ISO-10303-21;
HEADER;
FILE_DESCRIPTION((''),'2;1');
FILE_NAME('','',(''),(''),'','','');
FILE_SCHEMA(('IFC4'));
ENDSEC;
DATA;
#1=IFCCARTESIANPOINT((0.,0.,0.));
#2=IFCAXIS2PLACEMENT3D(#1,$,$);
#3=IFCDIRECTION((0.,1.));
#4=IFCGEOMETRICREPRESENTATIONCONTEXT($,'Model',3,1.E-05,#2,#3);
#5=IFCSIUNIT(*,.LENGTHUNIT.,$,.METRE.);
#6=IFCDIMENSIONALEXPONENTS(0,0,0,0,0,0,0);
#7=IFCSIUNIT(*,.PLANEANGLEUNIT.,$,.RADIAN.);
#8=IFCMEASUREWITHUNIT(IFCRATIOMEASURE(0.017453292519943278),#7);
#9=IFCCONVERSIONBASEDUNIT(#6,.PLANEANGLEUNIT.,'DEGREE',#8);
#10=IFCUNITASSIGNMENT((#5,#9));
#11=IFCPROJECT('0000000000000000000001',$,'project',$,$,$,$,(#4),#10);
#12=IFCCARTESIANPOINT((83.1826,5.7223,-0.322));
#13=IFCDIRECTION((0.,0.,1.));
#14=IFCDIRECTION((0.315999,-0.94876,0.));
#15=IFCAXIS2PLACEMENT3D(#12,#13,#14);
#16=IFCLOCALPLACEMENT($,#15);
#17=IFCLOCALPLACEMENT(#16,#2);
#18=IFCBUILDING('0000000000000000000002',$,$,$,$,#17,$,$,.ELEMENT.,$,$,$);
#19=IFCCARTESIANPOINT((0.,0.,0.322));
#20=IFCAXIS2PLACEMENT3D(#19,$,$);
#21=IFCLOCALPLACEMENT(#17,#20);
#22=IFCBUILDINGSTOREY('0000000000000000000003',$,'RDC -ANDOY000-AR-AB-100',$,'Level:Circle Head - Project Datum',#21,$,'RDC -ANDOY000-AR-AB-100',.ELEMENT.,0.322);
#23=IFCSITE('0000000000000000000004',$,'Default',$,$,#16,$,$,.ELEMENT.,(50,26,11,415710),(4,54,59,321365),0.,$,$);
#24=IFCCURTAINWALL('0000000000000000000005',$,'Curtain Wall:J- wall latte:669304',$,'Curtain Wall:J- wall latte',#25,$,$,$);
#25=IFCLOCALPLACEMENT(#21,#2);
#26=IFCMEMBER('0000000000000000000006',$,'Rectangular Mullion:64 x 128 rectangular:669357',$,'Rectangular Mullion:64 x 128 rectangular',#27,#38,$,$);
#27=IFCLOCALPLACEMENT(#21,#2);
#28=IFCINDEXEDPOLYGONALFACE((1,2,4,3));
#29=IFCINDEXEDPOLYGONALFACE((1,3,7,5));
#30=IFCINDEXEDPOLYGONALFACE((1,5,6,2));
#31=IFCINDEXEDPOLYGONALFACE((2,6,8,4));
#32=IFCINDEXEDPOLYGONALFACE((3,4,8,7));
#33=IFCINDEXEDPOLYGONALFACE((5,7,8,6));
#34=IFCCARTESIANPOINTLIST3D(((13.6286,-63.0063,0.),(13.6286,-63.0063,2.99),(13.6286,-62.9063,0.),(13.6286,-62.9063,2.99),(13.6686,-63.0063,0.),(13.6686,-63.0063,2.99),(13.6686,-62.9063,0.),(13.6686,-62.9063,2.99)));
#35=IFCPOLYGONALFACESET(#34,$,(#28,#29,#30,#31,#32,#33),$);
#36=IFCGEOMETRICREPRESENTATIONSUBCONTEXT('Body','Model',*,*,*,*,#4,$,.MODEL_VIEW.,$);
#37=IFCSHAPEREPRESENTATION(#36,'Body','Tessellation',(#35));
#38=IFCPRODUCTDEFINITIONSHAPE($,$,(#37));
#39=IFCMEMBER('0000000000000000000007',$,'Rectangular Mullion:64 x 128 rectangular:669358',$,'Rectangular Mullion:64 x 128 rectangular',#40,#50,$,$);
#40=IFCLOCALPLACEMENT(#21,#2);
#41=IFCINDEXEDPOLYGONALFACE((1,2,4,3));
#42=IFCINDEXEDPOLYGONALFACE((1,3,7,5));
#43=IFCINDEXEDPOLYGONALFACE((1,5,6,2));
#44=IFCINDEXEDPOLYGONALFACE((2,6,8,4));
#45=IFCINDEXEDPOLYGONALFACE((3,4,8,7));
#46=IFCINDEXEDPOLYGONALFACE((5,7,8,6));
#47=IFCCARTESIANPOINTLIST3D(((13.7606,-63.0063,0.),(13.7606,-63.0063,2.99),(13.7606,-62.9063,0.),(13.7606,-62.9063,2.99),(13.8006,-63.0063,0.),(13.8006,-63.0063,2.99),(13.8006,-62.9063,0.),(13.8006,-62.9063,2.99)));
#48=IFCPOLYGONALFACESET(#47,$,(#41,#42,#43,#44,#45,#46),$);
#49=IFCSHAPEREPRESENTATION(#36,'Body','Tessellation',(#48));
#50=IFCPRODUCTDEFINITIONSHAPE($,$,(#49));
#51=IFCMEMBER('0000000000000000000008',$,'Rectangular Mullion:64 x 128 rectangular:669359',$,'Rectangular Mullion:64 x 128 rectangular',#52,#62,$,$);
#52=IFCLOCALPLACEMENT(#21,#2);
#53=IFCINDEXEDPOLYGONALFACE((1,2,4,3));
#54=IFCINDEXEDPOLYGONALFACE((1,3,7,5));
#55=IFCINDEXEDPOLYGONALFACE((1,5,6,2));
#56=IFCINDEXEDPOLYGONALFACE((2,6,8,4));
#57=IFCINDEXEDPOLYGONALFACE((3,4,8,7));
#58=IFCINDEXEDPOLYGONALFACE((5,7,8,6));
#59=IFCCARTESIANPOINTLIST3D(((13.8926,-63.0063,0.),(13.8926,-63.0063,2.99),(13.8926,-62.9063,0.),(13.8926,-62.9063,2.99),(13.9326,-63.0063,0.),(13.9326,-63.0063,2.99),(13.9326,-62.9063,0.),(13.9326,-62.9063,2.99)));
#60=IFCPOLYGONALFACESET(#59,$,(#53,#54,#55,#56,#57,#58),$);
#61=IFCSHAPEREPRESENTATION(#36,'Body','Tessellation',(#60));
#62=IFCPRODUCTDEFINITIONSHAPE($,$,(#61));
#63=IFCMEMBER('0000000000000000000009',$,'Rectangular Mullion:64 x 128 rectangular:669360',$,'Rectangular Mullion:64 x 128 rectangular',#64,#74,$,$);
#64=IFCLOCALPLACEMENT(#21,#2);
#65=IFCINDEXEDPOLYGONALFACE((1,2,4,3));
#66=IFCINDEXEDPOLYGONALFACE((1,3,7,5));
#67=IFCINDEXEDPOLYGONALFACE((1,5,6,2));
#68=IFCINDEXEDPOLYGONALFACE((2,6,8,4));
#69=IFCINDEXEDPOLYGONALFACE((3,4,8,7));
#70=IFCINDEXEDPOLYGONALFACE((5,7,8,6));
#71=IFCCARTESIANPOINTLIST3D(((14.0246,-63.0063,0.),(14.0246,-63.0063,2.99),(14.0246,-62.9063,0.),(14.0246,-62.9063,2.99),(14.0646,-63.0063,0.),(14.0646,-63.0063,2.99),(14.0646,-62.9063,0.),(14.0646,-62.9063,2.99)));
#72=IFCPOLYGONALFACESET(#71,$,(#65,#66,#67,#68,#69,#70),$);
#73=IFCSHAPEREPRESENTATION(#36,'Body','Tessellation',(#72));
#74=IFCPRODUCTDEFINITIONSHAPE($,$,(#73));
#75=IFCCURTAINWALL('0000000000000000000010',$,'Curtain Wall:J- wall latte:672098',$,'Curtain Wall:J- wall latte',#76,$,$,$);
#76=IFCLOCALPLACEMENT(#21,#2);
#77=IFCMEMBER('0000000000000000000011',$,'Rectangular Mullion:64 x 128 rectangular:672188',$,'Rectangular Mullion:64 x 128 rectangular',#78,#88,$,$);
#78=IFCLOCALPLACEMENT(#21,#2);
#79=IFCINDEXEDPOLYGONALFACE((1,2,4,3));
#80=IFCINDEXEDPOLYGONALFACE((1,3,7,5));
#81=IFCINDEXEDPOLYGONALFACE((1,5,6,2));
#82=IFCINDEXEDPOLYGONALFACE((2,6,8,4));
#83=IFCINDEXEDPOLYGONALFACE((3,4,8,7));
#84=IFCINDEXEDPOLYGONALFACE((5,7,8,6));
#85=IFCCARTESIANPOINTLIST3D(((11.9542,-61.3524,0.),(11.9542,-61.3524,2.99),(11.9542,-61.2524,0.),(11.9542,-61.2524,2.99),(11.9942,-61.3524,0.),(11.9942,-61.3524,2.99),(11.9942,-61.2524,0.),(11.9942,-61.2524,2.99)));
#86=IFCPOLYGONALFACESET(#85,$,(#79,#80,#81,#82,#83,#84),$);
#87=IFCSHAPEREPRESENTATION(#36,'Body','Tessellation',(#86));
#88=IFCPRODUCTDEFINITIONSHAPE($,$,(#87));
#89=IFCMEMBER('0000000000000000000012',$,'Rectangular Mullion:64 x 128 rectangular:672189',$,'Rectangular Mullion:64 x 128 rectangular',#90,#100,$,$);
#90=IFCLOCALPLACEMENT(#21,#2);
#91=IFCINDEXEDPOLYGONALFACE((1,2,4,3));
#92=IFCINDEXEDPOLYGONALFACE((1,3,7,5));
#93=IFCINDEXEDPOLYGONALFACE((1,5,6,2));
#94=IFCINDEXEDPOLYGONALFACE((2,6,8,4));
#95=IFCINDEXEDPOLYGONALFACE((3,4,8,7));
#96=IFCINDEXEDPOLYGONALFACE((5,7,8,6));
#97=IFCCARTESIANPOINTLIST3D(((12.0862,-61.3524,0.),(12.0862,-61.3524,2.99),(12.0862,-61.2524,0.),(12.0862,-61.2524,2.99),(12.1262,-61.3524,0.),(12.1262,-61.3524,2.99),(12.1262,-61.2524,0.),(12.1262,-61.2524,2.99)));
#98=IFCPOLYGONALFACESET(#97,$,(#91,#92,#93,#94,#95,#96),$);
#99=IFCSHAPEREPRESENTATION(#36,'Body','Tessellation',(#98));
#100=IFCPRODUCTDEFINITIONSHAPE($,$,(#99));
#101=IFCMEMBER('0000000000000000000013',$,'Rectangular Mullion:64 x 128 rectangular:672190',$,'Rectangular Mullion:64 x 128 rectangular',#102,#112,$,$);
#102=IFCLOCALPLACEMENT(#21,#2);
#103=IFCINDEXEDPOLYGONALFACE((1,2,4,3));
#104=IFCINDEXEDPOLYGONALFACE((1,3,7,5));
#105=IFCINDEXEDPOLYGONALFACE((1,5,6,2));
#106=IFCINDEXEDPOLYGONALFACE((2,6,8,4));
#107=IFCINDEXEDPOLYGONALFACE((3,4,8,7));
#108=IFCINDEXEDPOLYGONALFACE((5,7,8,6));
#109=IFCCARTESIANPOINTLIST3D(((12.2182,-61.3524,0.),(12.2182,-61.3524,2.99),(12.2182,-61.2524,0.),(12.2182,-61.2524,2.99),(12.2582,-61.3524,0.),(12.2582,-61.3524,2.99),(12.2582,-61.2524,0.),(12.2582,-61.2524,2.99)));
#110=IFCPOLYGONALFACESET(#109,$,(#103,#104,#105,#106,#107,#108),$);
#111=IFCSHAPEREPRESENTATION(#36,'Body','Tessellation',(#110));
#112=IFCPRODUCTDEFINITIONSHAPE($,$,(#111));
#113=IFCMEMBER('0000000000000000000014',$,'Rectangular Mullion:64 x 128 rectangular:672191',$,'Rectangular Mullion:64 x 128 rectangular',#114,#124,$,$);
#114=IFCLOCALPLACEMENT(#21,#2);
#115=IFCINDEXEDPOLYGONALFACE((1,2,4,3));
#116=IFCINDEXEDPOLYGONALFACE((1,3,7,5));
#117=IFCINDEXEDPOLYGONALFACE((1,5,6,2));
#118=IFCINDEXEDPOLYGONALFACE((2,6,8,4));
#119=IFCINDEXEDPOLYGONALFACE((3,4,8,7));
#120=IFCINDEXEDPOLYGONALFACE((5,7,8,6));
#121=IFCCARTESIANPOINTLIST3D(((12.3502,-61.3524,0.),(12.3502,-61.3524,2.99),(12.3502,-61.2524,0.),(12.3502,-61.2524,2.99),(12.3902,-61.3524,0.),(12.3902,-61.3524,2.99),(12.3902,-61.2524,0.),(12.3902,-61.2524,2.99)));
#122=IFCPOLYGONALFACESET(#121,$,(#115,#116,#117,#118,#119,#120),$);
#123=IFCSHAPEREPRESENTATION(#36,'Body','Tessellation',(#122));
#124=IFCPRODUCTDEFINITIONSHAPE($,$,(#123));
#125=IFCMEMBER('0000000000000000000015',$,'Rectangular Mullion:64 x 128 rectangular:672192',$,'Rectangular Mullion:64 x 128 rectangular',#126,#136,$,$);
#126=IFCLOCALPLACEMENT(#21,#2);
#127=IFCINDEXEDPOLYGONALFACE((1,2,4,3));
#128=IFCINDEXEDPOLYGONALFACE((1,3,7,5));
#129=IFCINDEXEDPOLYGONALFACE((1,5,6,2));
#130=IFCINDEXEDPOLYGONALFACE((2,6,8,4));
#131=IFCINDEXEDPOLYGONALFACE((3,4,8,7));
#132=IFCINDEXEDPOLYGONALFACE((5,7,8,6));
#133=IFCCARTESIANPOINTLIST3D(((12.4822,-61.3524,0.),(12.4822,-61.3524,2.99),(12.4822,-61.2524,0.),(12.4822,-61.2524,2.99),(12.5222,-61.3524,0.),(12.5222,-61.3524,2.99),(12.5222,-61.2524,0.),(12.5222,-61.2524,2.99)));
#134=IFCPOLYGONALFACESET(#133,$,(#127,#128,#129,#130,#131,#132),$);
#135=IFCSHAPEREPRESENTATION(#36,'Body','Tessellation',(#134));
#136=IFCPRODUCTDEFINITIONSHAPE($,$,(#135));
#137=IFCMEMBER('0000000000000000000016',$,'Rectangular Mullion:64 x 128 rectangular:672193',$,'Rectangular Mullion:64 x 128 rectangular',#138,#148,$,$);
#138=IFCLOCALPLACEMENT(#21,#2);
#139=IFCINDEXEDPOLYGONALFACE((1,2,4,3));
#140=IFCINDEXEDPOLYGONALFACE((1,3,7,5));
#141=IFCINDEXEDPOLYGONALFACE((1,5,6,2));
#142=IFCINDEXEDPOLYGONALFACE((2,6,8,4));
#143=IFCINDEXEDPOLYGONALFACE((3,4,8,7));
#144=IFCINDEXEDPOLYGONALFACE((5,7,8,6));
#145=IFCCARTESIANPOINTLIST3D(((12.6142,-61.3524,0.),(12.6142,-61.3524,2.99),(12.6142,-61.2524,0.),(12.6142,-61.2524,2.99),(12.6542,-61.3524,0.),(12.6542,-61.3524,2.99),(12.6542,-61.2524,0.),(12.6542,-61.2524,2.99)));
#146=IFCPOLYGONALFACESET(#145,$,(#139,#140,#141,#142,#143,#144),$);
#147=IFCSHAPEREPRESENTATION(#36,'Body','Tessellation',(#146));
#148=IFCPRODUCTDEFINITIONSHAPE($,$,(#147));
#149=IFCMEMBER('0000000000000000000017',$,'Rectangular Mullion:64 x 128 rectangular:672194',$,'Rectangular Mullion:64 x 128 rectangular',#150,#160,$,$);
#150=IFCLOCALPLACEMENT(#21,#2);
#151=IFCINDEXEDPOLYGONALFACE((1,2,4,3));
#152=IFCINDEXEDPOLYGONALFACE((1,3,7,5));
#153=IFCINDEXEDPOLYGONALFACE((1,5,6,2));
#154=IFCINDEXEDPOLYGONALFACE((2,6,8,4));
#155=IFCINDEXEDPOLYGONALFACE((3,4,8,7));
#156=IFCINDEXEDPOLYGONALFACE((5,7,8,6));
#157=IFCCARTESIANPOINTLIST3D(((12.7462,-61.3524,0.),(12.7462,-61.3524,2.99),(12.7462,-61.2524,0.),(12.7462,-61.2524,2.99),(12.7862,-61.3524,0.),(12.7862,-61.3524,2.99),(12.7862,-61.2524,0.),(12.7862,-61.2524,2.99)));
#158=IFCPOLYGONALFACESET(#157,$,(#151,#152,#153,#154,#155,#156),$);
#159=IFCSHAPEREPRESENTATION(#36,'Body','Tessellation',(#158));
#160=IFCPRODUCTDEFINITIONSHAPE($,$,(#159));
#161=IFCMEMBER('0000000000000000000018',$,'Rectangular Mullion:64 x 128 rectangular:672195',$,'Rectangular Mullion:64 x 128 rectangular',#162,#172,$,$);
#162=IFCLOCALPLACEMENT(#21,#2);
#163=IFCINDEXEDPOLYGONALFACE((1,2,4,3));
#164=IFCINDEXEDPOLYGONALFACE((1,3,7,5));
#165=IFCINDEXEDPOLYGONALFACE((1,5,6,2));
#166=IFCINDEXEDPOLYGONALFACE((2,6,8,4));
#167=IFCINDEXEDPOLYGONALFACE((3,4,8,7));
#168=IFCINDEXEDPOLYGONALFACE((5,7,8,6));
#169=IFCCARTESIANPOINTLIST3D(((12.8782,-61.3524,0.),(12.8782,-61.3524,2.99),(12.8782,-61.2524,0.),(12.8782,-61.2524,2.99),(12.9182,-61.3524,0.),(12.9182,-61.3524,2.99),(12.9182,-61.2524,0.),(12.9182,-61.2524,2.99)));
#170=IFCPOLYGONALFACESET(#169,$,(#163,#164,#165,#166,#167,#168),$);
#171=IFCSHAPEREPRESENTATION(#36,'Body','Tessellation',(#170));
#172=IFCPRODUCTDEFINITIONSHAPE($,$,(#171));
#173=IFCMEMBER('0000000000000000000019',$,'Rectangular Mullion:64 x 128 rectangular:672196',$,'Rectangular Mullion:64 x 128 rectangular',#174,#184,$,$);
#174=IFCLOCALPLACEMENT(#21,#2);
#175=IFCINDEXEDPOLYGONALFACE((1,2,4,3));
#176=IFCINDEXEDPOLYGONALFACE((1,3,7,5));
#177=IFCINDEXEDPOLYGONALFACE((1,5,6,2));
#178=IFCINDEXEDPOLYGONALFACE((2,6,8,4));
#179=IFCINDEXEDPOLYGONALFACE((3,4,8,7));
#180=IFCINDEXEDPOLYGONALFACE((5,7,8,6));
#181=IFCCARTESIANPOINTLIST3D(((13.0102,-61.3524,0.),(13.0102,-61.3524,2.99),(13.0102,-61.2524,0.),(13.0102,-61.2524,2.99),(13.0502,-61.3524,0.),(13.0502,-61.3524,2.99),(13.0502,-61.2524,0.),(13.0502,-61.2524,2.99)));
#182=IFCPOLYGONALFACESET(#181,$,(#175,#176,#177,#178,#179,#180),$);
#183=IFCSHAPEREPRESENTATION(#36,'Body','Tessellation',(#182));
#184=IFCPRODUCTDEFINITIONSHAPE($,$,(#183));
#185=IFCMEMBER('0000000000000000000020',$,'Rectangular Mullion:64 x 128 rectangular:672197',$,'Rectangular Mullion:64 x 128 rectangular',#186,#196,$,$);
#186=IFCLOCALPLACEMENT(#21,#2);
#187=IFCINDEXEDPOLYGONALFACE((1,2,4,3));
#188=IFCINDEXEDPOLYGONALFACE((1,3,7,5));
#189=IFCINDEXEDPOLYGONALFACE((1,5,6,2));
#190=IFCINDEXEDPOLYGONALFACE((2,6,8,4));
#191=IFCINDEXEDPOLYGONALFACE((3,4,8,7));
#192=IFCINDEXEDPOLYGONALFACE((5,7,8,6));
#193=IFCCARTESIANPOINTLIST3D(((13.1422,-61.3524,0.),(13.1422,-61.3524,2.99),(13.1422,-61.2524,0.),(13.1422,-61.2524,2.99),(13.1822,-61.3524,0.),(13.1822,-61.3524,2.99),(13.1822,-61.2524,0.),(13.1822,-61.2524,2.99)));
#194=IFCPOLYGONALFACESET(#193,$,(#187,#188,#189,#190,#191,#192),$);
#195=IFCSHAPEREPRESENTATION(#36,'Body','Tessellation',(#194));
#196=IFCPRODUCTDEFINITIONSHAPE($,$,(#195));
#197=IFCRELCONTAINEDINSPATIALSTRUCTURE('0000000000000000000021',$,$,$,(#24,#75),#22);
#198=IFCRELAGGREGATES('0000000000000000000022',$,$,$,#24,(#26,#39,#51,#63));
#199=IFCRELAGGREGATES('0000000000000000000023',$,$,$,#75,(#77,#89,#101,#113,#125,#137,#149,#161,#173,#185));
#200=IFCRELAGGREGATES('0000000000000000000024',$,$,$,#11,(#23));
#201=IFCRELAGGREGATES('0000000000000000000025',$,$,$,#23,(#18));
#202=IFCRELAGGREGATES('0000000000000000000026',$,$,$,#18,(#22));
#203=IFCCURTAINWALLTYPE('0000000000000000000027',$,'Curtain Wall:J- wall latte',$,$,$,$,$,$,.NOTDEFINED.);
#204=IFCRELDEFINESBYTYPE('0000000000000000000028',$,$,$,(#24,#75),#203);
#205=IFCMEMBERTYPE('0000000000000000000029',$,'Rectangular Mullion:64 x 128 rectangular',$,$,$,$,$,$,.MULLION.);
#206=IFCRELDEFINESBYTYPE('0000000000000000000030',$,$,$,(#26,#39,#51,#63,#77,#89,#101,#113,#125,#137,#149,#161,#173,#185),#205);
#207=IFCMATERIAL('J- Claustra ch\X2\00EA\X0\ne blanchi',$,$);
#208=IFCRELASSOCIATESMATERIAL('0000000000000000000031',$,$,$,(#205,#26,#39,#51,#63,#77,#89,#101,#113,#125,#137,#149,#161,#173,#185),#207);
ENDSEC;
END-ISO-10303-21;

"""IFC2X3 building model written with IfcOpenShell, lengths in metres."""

from ifc_helpers import new_model, entity, si_unit, converted_unit, direction, frame, origin, origin_2d_with_axis, place, context, subcontext, project, spatial, rectangle, extrude, source, transform, mapped, material, type_object, type_shapes, element, aggregate, save


model = new_model("IFC2X3")

# Units and contexts
model_context = context("Model", 3, precision=1e-05, world=origin(), true_north=direction((0.0, 1.0)))
body_context = subcontext(model_context, "Body", "Model", "MODEL_VIEW")
ifc_project = project(units=[si_unit("LENGTHUNIT", "METRE"), converted_unit("PLANEANGLEUNIT", "DEGREE", entity("IfcRatioMeasure", 0.017453292519943278), si_unit("PLANEANGLEUNIT", "RADIAN"), dimensions=[0, 0, 0, 0, 0, 0, 0])], contexts=[model_context])

# Site, building, storey
site_placement = place(None, frame((83.1826, 5.7223, -0.322), z_axis=(0.0, 0.0, 1.0), x_axis=(0.315999, -0.94876, 0.0)))
site = spatial("IfcSite", under=ifc_project, at=site_placement, Name="Default", CompositionType="ELEMENT", RefLatitude=(50, 26, 11, 415710), RefLongitude=(4, 54, 59, 321365), RefElevation=0.0)
building_placement = place(site_placement, origin())
building = spatial("IfcBuilding", under=site, at=building_placement, CompositionType="ELEMENT")
storey_placement = place(building_placement, frame((0.0, 0.0, 0.322)))
storey = spatial("IfcBuildingStorey", under=building, at=storey_placement, Name="RDC -ANDOY000-AR-AB-100", ObjectType="Level:Circle Head - Project Datum", LongName="RDC -ANDOY000-AR-AB-100", CompositionType="ELEMENT", Elevation=0.322)

# Curtain walls, members
curtain_wall_type = type_object("IfcCurtainWallType", Name="Curtain Wall:J- wall latte", PredefinedType="NOTDEFINED")
curtain_wall_1_placement = place(storey_placement, frame((0.0, 0.0, -0.322)))
curtain_wall_1 = element("IfcCurtainWall", 1, at=curtain_wall_1_placement, inside=storey, type_object=curtain_wall_type, Name="Curtain Wall:J- wall latte:669304", ObjectType="Curtain Wall:J- wall latte")
ifc_material_1 = material(Name="J- Claustra chêne blanchi")
member_type = type_object("IfcMemberType", Name="Rectangular Mullion:64 x 128 rectangular", PredefinedType="MULLION", material=ifc_material_1)
shared_shape_1 = source(origin(), body_context, "Body", "SweptSolid", [
    extrude(rectangle(XDim=0.1, YDim=0.04, at=origin_2d_with_axis()), frame((0.0, 0.0, -2.99), z_axis=(0.0, 0.0, 1.0), x_axis=(0.0, -1.0, 0.0)), (0.0, 0.0, 1.0), 2.99),
])
type_shapes(member_type, [shared_shape_1])
member_1_placement = place(curtain_wall_1_placement, frame((13.6486, -62.9563, 0.322), z_axis=(0.0, 0.0, -1.0), x_axis=(1.0, 0.0, 0.0)))
member_1 = element("IfcMember", 2, at=member_1_placement, type_object=member_type, material=ifc_material_1, Name="Rectangular Mullion:64 x 128 rectangular:669357", ObjectType="Rectangular Mullion:64 x 128 rectangular", context=body_context, shape_type="MappedRepresentation", body=[
    mapped(shared_shape_1, transform((0.0, 0.0, 0.0), scale=1.0)),
])
member_2_placement = place(curtain_wall_1_placement, frame((13.7806, -62.9563, 0.322), z_axis=(0.0, 0.0, -1.0), x_axis=(1.0, 0.0, 0.0)))
member_2 = element("IfcMember", 3, at=member_2_placement, type_object=member_type, material=ifc_material_1, Name="Rectangular Mullion:64 x 128 rectangular:669358", ObjectType="Rectangular Mullion:64 x 128 rectangular", context=body_context, shape_type="MappedRepresentation", body=[
    mapped(shared_shape_1, transform((0.0, 0.0, 0.0), scale=1.0)),
])
member_3_placement = place(curtain_wall_1_placement, frame((13.9126, -62.9563, 0.322), z_axis=(0.0, 0.0, -1.0), x_axis=(1.0, 0.0, 0.0)))
member_3 = element("IfcMember", 4, at=member_3_placement, type_object=member_type, material=ifc_material_1, Name="Rectangular Mullion:64 x 128 rectangular:669359", ObjectType="Rectangular Mullion:64 x 128 rectangular", context=body_context, shape_type="MappedRepresentation", body=[
    mapped(shared_shape_1, transform((0.0, 0.0, 0.0), scale=1.0)),
])
member_4_placement = place(curtain_wall_1_placement, frame((14.0446, -62.9563, 0.322), z_axis=(0.0, 0.0, -1.0), x_axis=(1.0, 0.0, 0.0)))
member_4 = element("IfcMember", 5, at=member_4_placement, type_object=member_type, material=ifc_material_1, Name="Rectangular Mullion:64 x 128 rectangular:669360", ObjectType="Rectangular Mullion:64 x 128 rectangular", context=body_context, shape_type="MappedRepresentation", body=[
    mapped(shared_shape_1, transform((0.0, 0.0, 0.0), scale=1.0)),
])
curtain_wall_2_placement = place(storey_placement, frame((0.0, 0.0, -0.322)))
curtain_wall_2 = element("IfcCurtainWall", 6, at=curtain_wall_2_placement, inside=storey, type_object=curtain_wall_type, Name="Curtain Wall:J- wall latte:672098", ObjectType="Curtain Wall:J- wall latte")
member_5_placement = place(curtain_wall_2_placement, frame((11.9742, -61.3024, 0.322), z_axis=(0.0, 0.0, -1.0), x_axis=(1.0, 0.0, 0.0)))
member_5 = element("IfcMember", 7, at=member_5_placement, type_object=member_type, material=ifc_material_1, Name="Rectangular Mullion:64 x 128 rectangular:672188", ObjectType="Rectangular Mullion:64 x 128 rectangular", context=body_context, shape_type="MappedRepresentation", body=[
    mapped(shared_shape_1, transform((0.0, 0.0, 0.0), scale=1.0)),
])
member_6_placement = place(curtain_wall_2_placement, frame((12.1062, -61.3024, 0.322), z_axis=(0.0, 0.0, -1.0), x_axis=(1.0, 0.0, 0.0)))
member_6 = element("IfcMember", 8, at=member_6_placement, type_object=member_type, material=ifc_material_1, Name="Rectangular Mullion:64 x 128 rectangular:672189", ObjectType="Rectangular Mullion:64 x 128 rectangular", context=body_context, shape_type="MappedRepresentation", body=[
    mapped(shared_shape_1, transform((0.0, 0.0, 0.0), scale=1.0)),
])
member_7_placement = place(curtain_wall_2_placement, frame((12.2382, -61.3024, 0.322), z_axis=(0.0, 0.0, -1.0), x_axis=(1.0, 0.0, 0.0)))
member_7 = element("IfcMember", 9, at=member_7_placement, type_object=member_type, material=ifc_material_1, Name="Rectangular Mullion:64 x 128 rectangular:672190", ObjectType="Rectangular Mullion:64 x 128 rectangular", context=body_context, shape_type="MappedRepresentation", body=[
    mapped(shared_shape_1, transform((0.0, 0.0, 0.0), scale=1.0)),
])
member_8_placement = place(curtain_wall_2_placement, frame((12.3702, -61.3024, 0.322), z_axis=(0.0, 0.0, -1.0), x_axis=(1.0, 0.0, 0.0)))
member_8 = element("IfcMember", 10, at=member_8_placement, type_object=member_type, material=ifc_material_1, Name="Rectangular Mullion:64 x 128 rectangular:672191", ObjectType="Rectangular Mullion:64 x 128 rectangular", context=body_context, shape_type="MappedRepresentation", body=[
    mapped(shared_shape_1, transform((0.0, 0.0, 0.0), scale=1.0)),
])
member_9_placement = place(curtain_wall_2_placement, frame((12.5022, -61.3024, 0.322), z_axis=(0.0, 0.0, -1.0), x_axis=(1.0, 0.0, 0.0)))
member_9 = element("IfcMember", 11, at=member_9_placement, type_object=member_type, material=ifc_material_1, Name="Rectangular Mullion:64 x 128 rectangular:672192", ObjectType="Rectangular Mullion:64 x 128 rectangular", context=body_context, shape_type="MappedRepresentation", body=[
    mapped(shared_shape_1, transform((0.0, 0.0, 0.0), scale=1.0)),
])
member_10_placement = place(curtain_wall_2_placement, frame((12.6342, -61.3024, 0.322), z_axis=(0.0, 0.0, -1.0), x_axis=(1.0, 0.0, 0.0)))
member_10 = element("IfcMember", 12, at=member_10_placement, type_object=member_type, material=ifc_material_1, Name="Rectangular Mullion:64 x 128 rectangular:672193", ObjectType="Rectangular Mullion:64 x 128 rectangular", context=body_context, shape_type="MappedRepresentation", body=[
    mapped(shared_shape_1, transform((0.0, 0.0, 0.0), scale=1.0)),
])
member_11_placement = place(curtain_wall_2_placement, frame((12.7662, -61.3024, 0.322), z_axis=(0.0, 0.0, -1.0), x_axis=(1.0, 0.0, 0.0)))
member_11 = element("IfcMember", 13, at=member_11_placement, type_object=member_type, material=ifc_material_1, Name="Rectangular Mullion:64 x 128 rectangular:672194", ObjectType="Rectangular Mullion:64 x 128 rectangular", context=body_context, shape_type="MappedRepresentation", body=[
    mapped(shared_shape_1, transform((0.0, 0.0, 0.0), scale=1.0)),
])
member_12_placement = place(curtain_wall_2_placement, frame((12.8982, -61.3024, 0.322), z_axis=(0.0, 0.0, -1.0), x_axis=(1.0, 0.0, 0.0)))
member_12 = element("IfcMember", 14, at=member_12_placement, type_object=member_type, material=ifc_material_1, Name="Rectangular Mullion:64 x 128 rectangular:672195", ObjectType="Rectangular Mullion:64 x 128 rectangular", context=body_context, shape_type="MappedRepresentation", body=[
    mapped(shared_shape_1, transform((0.0, 0.0, 0.0), scale=1.0)),
])
member_13_placement = place(curtain_wall_2_placement, frame((13.0302, -61.3024, 0.322), z_axis=(0.0, 0.0, -1.0), x_axis=(1.0, 0.0, 0.0)))
member_13 = element("IfcMember", 15, at=member_13_placement, type_object=member_type, material=ifc_material_1, Name="Rectangular Mullion:64 x 128 rectangular:672196", ObjectType="Rectangular Mullion:64 x 128 rectangular", context=body_context, shape_type="MappedRepresentation", body=[
    mapped(shared_shape_1, transform((0.0, 0.0, 0.0), scale=1.0)),
])
member_14_placement = place(curtain_wall_2_placement, frame((13.1622, -61.3024, 0.322), z_axis=(0.0, 0.0, -1.0), x_axis=(1.0, 0.0, 0.0)))
member_14 = element("IfcMember", 16, at=member_14_placement, type_object=member_type, material=ifc_material_1, Name="Rectangular Mullion:64 x 128 rectangular:672197", ObjectType="Rectangular Mullion:64 x 128 rectangular", context=body_context, shape_type="MappedRepresentation", body=[
    mapped(shared_shape_1, transform((0.0, 0.0, 0.0), scale=1.0)),
])

aggregate(curtain_wall_1, [member_1, member_2, member_3, member_4])
aggregate(curtain_wall_2, [member_5, member_6, member_7, member_8, member_9, member_10, member_11, member_12, member_13, member_14])

save(model, "model.ifc")
